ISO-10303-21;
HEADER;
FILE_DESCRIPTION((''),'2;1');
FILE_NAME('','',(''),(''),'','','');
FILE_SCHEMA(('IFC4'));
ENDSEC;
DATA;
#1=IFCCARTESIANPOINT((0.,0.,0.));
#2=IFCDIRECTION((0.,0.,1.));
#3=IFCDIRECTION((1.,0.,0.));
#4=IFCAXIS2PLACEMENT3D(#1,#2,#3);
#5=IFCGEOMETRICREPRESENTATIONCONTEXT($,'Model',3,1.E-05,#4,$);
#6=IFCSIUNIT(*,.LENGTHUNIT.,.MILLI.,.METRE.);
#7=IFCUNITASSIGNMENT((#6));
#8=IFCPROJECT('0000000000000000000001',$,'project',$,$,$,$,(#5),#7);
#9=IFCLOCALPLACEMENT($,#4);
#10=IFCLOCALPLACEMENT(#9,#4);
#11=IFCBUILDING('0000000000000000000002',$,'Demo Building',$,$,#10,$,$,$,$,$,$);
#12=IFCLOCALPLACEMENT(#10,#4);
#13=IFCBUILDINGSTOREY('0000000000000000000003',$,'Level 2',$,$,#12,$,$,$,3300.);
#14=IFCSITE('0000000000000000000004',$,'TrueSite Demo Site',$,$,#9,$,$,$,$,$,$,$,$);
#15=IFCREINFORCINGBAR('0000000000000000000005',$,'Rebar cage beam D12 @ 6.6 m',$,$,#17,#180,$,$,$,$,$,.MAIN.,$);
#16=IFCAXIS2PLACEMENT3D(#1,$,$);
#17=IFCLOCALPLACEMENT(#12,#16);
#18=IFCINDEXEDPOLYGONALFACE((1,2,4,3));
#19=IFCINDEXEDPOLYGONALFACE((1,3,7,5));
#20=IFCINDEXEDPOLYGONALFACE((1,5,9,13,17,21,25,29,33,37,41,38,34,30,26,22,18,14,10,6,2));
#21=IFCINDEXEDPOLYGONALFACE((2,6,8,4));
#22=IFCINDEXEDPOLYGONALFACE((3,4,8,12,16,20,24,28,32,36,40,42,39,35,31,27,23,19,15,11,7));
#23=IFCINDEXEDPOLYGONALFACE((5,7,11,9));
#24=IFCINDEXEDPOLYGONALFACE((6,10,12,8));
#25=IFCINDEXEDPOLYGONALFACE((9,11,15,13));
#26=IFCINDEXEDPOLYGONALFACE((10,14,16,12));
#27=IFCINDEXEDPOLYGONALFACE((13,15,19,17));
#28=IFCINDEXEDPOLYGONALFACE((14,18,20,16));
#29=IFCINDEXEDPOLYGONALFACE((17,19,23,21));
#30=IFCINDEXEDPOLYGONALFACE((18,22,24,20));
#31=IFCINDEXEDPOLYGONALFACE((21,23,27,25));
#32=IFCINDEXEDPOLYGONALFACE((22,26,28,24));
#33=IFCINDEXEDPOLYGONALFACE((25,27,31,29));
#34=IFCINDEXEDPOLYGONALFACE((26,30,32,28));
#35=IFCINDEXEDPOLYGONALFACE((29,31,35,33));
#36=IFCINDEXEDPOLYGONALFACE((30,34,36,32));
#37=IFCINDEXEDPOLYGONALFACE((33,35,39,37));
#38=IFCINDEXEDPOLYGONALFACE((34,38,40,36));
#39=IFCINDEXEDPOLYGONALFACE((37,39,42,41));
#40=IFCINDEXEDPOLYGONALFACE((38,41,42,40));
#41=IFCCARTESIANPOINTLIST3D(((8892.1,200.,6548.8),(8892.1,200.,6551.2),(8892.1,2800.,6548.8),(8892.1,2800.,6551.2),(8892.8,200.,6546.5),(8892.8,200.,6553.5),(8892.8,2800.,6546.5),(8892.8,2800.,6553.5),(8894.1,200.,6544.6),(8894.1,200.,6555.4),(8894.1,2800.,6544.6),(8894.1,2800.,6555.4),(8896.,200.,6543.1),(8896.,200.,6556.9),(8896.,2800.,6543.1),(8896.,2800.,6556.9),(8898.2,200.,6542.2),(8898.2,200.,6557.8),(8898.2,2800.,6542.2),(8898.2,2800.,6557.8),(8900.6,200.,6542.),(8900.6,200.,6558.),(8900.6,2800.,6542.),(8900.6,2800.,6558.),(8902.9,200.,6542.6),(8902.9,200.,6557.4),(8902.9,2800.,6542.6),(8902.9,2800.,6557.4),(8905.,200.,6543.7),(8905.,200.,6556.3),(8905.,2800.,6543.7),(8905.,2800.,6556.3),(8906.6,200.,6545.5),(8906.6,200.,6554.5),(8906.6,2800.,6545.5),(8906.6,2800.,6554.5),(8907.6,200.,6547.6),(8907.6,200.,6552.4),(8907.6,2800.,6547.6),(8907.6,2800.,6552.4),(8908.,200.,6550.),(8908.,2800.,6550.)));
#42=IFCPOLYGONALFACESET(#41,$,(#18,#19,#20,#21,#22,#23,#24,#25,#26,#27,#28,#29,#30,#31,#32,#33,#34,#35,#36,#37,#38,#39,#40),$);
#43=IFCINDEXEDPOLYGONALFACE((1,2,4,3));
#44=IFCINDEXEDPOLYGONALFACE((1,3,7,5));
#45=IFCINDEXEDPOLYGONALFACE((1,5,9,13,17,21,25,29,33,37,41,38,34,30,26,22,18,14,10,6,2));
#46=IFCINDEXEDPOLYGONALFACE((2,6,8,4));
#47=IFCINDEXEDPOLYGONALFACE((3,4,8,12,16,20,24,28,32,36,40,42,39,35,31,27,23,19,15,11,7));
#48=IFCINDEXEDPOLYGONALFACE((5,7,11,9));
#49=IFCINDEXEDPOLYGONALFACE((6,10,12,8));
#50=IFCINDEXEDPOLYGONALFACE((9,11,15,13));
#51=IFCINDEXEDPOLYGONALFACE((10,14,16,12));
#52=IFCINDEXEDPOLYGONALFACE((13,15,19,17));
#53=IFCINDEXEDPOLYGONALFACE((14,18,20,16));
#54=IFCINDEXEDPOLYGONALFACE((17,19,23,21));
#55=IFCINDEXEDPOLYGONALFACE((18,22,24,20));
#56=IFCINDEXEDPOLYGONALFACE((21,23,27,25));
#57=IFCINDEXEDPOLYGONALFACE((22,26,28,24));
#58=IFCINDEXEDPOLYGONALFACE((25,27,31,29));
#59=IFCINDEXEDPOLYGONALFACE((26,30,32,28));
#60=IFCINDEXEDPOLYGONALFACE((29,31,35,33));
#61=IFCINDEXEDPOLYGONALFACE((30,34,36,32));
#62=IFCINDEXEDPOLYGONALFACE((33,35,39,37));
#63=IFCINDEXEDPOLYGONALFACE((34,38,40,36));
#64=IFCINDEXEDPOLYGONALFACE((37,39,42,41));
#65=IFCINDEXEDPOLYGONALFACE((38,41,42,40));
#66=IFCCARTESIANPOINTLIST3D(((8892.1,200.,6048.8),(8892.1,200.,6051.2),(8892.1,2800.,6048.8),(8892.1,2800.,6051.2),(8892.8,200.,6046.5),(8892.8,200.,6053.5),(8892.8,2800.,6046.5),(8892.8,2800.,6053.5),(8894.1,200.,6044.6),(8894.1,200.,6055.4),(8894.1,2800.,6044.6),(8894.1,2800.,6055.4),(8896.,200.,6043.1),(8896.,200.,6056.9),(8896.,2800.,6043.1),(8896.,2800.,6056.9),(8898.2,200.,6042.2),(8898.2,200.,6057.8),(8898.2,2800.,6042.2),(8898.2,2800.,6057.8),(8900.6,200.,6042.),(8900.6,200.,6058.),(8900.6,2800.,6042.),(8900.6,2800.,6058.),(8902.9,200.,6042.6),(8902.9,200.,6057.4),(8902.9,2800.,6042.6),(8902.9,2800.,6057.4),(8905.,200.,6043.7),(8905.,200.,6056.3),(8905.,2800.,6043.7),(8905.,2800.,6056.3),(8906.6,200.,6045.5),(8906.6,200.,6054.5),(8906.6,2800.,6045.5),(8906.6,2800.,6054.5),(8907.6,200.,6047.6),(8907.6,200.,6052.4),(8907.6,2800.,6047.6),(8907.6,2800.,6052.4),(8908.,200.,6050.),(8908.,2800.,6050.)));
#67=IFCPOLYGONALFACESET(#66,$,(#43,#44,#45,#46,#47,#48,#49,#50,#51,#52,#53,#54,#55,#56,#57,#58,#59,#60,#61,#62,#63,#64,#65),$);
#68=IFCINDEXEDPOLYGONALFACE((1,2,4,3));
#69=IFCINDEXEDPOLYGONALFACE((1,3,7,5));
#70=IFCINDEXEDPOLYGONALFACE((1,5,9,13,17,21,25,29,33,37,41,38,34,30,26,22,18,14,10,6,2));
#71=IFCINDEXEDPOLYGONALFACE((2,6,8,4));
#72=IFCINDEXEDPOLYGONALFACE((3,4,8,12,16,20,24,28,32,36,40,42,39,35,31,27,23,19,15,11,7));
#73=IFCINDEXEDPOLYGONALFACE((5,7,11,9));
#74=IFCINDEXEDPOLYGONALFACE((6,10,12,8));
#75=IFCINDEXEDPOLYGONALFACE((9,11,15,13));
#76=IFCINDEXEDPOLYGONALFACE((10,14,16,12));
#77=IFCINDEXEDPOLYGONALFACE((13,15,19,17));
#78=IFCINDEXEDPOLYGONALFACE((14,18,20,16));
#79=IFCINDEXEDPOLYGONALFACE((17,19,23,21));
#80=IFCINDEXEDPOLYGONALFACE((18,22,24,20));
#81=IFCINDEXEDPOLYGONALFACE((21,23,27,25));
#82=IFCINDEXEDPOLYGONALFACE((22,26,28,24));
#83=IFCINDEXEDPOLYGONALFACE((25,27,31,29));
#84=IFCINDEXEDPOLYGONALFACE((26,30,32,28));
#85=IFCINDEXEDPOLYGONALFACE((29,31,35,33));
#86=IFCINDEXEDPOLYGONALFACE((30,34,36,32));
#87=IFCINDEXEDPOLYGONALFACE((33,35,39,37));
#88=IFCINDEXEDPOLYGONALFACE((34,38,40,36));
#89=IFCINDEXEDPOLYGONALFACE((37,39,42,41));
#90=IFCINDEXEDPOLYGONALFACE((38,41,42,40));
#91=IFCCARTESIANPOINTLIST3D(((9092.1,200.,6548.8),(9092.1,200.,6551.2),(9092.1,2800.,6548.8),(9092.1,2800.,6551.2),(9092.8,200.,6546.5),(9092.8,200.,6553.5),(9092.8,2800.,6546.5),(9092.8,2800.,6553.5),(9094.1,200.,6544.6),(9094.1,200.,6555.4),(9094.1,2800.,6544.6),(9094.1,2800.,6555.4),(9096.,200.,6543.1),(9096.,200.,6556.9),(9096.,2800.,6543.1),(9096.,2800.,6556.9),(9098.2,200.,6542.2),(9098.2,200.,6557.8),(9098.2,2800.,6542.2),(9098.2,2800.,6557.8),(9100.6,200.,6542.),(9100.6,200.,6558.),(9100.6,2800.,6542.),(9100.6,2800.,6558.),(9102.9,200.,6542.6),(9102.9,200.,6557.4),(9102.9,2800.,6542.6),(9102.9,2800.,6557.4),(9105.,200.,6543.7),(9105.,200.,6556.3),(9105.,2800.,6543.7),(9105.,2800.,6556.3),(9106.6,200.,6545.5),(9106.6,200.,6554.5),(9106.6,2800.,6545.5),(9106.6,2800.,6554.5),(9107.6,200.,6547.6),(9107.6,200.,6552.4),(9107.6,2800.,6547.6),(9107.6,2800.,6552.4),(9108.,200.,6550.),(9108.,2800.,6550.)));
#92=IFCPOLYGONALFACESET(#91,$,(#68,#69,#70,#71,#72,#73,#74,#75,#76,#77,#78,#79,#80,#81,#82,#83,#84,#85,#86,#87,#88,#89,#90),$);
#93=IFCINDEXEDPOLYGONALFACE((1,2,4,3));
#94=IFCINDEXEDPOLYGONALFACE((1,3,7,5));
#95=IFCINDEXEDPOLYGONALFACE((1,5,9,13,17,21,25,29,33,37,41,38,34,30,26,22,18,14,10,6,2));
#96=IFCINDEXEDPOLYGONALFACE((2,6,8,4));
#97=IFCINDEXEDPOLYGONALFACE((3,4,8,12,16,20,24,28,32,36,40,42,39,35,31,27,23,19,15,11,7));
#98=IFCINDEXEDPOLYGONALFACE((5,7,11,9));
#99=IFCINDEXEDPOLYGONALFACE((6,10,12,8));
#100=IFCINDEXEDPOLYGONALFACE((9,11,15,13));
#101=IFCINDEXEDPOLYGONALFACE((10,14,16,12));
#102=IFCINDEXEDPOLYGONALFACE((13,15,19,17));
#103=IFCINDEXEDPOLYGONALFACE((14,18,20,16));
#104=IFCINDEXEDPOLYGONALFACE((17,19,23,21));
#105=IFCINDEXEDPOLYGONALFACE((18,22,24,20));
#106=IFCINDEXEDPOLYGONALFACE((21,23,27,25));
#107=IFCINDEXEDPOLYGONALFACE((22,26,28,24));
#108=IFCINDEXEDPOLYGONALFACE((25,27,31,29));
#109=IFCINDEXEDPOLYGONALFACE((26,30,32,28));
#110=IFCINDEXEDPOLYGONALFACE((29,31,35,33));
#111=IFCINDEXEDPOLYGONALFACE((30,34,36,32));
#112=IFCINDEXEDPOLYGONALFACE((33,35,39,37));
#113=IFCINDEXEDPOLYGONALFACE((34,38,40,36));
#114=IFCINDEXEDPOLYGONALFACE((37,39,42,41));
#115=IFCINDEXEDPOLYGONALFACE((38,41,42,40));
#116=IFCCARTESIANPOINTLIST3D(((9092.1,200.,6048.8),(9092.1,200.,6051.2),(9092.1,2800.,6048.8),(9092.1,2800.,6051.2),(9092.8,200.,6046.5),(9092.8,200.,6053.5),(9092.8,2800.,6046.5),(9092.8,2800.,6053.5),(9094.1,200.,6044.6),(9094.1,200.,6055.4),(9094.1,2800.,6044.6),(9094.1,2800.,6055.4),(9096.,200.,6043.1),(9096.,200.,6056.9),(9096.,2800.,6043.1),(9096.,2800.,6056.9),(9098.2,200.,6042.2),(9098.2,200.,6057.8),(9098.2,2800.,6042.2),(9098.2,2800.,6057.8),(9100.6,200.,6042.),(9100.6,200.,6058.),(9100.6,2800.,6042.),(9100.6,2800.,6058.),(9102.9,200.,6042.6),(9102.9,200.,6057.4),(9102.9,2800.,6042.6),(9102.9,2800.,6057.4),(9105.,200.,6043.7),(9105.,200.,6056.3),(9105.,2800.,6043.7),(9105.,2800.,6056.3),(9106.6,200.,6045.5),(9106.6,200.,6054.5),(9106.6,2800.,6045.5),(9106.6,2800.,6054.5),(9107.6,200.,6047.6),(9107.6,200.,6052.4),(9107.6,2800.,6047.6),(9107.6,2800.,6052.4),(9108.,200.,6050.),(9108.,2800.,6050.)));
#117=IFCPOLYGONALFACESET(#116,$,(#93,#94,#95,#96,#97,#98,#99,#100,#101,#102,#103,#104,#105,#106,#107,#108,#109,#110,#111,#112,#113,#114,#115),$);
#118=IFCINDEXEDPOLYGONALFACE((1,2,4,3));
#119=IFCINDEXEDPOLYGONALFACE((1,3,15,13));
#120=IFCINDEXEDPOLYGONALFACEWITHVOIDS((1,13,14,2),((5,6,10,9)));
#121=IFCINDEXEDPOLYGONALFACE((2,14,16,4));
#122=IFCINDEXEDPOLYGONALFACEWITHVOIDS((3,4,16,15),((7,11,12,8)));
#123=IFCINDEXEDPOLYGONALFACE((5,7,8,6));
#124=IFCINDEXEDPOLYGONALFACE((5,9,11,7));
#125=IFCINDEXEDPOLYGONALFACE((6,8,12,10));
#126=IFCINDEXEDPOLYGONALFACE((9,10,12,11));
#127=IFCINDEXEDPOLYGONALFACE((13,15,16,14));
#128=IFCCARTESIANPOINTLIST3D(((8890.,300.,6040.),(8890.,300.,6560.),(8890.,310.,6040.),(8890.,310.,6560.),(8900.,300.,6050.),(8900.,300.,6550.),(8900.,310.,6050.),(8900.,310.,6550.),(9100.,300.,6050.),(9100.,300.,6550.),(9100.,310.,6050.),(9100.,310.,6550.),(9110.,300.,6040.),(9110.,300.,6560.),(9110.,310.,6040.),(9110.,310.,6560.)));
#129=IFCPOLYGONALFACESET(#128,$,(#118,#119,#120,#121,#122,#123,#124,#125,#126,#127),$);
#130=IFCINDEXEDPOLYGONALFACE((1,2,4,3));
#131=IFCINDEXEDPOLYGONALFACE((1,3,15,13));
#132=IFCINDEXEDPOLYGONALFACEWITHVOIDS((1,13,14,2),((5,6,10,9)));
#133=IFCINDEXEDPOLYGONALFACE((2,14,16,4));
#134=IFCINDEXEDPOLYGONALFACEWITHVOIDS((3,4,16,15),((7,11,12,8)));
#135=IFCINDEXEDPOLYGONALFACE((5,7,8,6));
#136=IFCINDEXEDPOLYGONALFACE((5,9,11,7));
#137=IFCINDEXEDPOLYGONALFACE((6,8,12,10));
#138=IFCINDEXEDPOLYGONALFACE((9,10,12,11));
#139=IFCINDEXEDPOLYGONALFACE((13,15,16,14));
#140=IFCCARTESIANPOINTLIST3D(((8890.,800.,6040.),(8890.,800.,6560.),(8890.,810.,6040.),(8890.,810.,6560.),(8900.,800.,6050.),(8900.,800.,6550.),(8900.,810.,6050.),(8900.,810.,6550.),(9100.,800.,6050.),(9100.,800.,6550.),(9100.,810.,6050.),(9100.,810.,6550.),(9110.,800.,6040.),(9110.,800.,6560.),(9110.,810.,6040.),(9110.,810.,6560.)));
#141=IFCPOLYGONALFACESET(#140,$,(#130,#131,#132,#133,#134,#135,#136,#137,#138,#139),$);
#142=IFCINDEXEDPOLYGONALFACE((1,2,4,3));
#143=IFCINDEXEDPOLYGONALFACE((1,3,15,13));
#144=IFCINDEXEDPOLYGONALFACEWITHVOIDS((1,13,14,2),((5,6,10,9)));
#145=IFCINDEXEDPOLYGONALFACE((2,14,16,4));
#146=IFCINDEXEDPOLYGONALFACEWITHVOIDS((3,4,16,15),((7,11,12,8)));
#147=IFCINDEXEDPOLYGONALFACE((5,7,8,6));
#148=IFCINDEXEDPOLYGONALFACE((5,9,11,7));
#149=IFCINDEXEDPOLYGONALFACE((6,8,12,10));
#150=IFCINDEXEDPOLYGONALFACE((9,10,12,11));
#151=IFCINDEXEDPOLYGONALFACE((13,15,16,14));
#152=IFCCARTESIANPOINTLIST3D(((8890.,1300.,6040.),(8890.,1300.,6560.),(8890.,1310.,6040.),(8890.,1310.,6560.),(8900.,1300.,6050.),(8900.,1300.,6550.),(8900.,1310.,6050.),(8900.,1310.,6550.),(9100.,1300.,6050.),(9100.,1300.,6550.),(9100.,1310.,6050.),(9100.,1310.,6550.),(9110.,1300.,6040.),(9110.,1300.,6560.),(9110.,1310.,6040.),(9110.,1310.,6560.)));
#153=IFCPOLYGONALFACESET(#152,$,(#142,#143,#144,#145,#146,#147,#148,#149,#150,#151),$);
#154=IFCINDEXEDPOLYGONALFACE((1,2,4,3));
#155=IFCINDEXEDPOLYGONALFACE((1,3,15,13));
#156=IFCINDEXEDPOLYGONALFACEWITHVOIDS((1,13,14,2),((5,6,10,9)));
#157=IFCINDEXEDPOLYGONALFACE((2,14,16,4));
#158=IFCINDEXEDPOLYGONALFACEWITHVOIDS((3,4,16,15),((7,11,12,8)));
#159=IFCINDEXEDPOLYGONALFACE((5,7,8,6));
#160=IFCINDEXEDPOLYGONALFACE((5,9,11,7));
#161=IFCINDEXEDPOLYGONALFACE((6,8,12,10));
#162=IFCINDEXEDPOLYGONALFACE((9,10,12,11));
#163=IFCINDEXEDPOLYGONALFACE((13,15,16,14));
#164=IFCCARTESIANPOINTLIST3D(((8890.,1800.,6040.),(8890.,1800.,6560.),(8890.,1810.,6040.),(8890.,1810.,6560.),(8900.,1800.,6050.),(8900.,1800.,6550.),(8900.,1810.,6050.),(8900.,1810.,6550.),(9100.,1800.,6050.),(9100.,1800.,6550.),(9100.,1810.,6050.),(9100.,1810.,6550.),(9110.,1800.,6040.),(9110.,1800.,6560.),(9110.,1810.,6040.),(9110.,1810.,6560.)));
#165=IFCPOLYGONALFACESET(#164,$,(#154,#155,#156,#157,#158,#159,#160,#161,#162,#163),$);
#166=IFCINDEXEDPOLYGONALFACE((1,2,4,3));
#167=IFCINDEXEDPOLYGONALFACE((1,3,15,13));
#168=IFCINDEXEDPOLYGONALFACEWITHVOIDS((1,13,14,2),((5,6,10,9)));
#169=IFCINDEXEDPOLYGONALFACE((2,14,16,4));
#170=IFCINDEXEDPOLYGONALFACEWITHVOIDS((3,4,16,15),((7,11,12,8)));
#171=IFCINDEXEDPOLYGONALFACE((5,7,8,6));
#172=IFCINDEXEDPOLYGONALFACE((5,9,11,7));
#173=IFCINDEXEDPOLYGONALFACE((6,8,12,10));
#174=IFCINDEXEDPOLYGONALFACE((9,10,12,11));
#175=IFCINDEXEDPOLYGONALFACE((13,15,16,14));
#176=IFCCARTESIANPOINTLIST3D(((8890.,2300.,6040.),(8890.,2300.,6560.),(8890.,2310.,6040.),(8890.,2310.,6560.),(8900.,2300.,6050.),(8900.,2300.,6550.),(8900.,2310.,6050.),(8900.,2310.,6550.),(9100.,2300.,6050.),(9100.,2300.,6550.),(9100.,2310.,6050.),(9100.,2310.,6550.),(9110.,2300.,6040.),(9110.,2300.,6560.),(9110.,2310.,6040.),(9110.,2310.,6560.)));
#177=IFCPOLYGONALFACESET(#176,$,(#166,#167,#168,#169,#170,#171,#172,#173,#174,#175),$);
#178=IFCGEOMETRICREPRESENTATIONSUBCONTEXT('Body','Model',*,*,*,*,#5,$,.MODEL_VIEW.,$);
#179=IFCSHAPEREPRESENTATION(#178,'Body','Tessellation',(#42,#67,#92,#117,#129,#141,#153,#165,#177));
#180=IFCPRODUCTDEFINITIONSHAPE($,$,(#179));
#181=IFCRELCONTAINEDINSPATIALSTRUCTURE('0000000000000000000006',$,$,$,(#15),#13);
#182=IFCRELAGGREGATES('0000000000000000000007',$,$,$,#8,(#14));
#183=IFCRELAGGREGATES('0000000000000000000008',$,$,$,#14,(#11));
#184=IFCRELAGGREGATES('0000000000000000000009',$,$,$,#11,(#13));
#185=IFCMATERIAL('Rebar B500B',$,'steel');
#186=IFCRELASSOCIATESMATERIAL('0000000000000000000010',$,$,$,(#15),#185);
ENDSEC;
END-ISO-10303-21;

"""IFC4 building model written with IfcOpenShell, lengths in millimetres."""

from ifc_helpers import new_model, si_unit, frame, origin_with_axes, place, context, subcontext, project, spatial, hollow_rectangle, circle, extrude, material, element, save


model = new_model("IFC4")

# Units and contexts
model_context = context("Model", 3, precision=1e-05, world=origin_with_axes())
body_context = subcontext(model_context, "Body", "Model", "MODEL_VIEW")
ifc_project = project(units=[si_unit("LENGTHUNIT", "METRE", prefix="MILLI")], contexts=[model_context])

# Site, building, storey
site_placement = place(None, origin_with_axes())
site = spatial("IfcSite", under=ifc_project, at=site_placement, Name="TrueSite Demo Site")
building_placement = place(site_placement, origin_with_axes())
building = spatial("IfcBuilding", under=site, at=building_placement, Name="Demo Building")
storey_placement = place(building_placement, origin_with_axes())
storey = spatial("IfcBuildingStorey", under=building, at=storey_placement, Name="Level 2", Elevation=3300.0)

# Reinforcing bar
ifc_material_1 = material(Name="Rebar B500B", Category="steel")
for number, where, z_axis, x_axis, name in (
    (1, (9000.0, 200.0, 6300.0), (0.0, 1.0, 0.0), (1.0, 0.0, 0.0), "Rebar cage beam D12 @ 6.6 m"),
):
    element("IfcReinforcingBar", number, at=place(storey_placement, frame(where, z_axis=z_axis, x_axis=x_axis)), inside=storey, material=ifc_material_1, Name=name, PredefinedType="MAIN", context=body_context, shape_type="SweptSolid", body=[
        extrude(circle(Radius=8.0), frame((-100.0, -250.0, 0.0)), (0.0, 0.0, 1.0), 2600.0),
        extrude(circle(Radius=8.0), frame((-100.0, 250.0, 0.0)), (0.0, 0.0, 1.0), 2600.0),
        extrude(circle(Radius=8.0), frame((100.0, -250.0, 0.0)), (0.0, 0.0, 1.0), 2600.0),
        extrude(circle(Radius=8.0), frame((100.0, 250.0, 0.0)), (0.0, 0.0, 1.0), 2600.0),
        extrude(hollow_rectangle(XDim=220.0, YDim=520.0, WallThickness=10.0), frame((0.0, 0.0, 100.0)), (0.0, 0.0, 1.0), 10.0),
        extrude(hollow_rectangle(XDim=220.0, YDim=520.0, WallThickness=10.0), frame((0.0, 0.0, 600.0)), (0.0, 0.0, 1.0), 10.0),
        extrude(hollow_rectangle(XDim=220.0, YDim=520.0, WallThickness=10.0), frame((0.0, 0.0, 1100.0)), (0.0, 0.0, 1.0), 10.0),
        extrude(hollow_rectangle(XDim=220.0, YDim=520.0, WallThickness=10.0), frame((0.0, 0.0, 1600.0)), (0.0, 0.0, 1.0), 10.0),
        extrude(hollow_rectangle(XDim=220.0, YDim=520.0, WallThickness=10.0), frame((0.0, 0.0, 2100.0)), (0.0, 0.0, 1.0), 10.0),
    ])

save(model, "model.ifc")
